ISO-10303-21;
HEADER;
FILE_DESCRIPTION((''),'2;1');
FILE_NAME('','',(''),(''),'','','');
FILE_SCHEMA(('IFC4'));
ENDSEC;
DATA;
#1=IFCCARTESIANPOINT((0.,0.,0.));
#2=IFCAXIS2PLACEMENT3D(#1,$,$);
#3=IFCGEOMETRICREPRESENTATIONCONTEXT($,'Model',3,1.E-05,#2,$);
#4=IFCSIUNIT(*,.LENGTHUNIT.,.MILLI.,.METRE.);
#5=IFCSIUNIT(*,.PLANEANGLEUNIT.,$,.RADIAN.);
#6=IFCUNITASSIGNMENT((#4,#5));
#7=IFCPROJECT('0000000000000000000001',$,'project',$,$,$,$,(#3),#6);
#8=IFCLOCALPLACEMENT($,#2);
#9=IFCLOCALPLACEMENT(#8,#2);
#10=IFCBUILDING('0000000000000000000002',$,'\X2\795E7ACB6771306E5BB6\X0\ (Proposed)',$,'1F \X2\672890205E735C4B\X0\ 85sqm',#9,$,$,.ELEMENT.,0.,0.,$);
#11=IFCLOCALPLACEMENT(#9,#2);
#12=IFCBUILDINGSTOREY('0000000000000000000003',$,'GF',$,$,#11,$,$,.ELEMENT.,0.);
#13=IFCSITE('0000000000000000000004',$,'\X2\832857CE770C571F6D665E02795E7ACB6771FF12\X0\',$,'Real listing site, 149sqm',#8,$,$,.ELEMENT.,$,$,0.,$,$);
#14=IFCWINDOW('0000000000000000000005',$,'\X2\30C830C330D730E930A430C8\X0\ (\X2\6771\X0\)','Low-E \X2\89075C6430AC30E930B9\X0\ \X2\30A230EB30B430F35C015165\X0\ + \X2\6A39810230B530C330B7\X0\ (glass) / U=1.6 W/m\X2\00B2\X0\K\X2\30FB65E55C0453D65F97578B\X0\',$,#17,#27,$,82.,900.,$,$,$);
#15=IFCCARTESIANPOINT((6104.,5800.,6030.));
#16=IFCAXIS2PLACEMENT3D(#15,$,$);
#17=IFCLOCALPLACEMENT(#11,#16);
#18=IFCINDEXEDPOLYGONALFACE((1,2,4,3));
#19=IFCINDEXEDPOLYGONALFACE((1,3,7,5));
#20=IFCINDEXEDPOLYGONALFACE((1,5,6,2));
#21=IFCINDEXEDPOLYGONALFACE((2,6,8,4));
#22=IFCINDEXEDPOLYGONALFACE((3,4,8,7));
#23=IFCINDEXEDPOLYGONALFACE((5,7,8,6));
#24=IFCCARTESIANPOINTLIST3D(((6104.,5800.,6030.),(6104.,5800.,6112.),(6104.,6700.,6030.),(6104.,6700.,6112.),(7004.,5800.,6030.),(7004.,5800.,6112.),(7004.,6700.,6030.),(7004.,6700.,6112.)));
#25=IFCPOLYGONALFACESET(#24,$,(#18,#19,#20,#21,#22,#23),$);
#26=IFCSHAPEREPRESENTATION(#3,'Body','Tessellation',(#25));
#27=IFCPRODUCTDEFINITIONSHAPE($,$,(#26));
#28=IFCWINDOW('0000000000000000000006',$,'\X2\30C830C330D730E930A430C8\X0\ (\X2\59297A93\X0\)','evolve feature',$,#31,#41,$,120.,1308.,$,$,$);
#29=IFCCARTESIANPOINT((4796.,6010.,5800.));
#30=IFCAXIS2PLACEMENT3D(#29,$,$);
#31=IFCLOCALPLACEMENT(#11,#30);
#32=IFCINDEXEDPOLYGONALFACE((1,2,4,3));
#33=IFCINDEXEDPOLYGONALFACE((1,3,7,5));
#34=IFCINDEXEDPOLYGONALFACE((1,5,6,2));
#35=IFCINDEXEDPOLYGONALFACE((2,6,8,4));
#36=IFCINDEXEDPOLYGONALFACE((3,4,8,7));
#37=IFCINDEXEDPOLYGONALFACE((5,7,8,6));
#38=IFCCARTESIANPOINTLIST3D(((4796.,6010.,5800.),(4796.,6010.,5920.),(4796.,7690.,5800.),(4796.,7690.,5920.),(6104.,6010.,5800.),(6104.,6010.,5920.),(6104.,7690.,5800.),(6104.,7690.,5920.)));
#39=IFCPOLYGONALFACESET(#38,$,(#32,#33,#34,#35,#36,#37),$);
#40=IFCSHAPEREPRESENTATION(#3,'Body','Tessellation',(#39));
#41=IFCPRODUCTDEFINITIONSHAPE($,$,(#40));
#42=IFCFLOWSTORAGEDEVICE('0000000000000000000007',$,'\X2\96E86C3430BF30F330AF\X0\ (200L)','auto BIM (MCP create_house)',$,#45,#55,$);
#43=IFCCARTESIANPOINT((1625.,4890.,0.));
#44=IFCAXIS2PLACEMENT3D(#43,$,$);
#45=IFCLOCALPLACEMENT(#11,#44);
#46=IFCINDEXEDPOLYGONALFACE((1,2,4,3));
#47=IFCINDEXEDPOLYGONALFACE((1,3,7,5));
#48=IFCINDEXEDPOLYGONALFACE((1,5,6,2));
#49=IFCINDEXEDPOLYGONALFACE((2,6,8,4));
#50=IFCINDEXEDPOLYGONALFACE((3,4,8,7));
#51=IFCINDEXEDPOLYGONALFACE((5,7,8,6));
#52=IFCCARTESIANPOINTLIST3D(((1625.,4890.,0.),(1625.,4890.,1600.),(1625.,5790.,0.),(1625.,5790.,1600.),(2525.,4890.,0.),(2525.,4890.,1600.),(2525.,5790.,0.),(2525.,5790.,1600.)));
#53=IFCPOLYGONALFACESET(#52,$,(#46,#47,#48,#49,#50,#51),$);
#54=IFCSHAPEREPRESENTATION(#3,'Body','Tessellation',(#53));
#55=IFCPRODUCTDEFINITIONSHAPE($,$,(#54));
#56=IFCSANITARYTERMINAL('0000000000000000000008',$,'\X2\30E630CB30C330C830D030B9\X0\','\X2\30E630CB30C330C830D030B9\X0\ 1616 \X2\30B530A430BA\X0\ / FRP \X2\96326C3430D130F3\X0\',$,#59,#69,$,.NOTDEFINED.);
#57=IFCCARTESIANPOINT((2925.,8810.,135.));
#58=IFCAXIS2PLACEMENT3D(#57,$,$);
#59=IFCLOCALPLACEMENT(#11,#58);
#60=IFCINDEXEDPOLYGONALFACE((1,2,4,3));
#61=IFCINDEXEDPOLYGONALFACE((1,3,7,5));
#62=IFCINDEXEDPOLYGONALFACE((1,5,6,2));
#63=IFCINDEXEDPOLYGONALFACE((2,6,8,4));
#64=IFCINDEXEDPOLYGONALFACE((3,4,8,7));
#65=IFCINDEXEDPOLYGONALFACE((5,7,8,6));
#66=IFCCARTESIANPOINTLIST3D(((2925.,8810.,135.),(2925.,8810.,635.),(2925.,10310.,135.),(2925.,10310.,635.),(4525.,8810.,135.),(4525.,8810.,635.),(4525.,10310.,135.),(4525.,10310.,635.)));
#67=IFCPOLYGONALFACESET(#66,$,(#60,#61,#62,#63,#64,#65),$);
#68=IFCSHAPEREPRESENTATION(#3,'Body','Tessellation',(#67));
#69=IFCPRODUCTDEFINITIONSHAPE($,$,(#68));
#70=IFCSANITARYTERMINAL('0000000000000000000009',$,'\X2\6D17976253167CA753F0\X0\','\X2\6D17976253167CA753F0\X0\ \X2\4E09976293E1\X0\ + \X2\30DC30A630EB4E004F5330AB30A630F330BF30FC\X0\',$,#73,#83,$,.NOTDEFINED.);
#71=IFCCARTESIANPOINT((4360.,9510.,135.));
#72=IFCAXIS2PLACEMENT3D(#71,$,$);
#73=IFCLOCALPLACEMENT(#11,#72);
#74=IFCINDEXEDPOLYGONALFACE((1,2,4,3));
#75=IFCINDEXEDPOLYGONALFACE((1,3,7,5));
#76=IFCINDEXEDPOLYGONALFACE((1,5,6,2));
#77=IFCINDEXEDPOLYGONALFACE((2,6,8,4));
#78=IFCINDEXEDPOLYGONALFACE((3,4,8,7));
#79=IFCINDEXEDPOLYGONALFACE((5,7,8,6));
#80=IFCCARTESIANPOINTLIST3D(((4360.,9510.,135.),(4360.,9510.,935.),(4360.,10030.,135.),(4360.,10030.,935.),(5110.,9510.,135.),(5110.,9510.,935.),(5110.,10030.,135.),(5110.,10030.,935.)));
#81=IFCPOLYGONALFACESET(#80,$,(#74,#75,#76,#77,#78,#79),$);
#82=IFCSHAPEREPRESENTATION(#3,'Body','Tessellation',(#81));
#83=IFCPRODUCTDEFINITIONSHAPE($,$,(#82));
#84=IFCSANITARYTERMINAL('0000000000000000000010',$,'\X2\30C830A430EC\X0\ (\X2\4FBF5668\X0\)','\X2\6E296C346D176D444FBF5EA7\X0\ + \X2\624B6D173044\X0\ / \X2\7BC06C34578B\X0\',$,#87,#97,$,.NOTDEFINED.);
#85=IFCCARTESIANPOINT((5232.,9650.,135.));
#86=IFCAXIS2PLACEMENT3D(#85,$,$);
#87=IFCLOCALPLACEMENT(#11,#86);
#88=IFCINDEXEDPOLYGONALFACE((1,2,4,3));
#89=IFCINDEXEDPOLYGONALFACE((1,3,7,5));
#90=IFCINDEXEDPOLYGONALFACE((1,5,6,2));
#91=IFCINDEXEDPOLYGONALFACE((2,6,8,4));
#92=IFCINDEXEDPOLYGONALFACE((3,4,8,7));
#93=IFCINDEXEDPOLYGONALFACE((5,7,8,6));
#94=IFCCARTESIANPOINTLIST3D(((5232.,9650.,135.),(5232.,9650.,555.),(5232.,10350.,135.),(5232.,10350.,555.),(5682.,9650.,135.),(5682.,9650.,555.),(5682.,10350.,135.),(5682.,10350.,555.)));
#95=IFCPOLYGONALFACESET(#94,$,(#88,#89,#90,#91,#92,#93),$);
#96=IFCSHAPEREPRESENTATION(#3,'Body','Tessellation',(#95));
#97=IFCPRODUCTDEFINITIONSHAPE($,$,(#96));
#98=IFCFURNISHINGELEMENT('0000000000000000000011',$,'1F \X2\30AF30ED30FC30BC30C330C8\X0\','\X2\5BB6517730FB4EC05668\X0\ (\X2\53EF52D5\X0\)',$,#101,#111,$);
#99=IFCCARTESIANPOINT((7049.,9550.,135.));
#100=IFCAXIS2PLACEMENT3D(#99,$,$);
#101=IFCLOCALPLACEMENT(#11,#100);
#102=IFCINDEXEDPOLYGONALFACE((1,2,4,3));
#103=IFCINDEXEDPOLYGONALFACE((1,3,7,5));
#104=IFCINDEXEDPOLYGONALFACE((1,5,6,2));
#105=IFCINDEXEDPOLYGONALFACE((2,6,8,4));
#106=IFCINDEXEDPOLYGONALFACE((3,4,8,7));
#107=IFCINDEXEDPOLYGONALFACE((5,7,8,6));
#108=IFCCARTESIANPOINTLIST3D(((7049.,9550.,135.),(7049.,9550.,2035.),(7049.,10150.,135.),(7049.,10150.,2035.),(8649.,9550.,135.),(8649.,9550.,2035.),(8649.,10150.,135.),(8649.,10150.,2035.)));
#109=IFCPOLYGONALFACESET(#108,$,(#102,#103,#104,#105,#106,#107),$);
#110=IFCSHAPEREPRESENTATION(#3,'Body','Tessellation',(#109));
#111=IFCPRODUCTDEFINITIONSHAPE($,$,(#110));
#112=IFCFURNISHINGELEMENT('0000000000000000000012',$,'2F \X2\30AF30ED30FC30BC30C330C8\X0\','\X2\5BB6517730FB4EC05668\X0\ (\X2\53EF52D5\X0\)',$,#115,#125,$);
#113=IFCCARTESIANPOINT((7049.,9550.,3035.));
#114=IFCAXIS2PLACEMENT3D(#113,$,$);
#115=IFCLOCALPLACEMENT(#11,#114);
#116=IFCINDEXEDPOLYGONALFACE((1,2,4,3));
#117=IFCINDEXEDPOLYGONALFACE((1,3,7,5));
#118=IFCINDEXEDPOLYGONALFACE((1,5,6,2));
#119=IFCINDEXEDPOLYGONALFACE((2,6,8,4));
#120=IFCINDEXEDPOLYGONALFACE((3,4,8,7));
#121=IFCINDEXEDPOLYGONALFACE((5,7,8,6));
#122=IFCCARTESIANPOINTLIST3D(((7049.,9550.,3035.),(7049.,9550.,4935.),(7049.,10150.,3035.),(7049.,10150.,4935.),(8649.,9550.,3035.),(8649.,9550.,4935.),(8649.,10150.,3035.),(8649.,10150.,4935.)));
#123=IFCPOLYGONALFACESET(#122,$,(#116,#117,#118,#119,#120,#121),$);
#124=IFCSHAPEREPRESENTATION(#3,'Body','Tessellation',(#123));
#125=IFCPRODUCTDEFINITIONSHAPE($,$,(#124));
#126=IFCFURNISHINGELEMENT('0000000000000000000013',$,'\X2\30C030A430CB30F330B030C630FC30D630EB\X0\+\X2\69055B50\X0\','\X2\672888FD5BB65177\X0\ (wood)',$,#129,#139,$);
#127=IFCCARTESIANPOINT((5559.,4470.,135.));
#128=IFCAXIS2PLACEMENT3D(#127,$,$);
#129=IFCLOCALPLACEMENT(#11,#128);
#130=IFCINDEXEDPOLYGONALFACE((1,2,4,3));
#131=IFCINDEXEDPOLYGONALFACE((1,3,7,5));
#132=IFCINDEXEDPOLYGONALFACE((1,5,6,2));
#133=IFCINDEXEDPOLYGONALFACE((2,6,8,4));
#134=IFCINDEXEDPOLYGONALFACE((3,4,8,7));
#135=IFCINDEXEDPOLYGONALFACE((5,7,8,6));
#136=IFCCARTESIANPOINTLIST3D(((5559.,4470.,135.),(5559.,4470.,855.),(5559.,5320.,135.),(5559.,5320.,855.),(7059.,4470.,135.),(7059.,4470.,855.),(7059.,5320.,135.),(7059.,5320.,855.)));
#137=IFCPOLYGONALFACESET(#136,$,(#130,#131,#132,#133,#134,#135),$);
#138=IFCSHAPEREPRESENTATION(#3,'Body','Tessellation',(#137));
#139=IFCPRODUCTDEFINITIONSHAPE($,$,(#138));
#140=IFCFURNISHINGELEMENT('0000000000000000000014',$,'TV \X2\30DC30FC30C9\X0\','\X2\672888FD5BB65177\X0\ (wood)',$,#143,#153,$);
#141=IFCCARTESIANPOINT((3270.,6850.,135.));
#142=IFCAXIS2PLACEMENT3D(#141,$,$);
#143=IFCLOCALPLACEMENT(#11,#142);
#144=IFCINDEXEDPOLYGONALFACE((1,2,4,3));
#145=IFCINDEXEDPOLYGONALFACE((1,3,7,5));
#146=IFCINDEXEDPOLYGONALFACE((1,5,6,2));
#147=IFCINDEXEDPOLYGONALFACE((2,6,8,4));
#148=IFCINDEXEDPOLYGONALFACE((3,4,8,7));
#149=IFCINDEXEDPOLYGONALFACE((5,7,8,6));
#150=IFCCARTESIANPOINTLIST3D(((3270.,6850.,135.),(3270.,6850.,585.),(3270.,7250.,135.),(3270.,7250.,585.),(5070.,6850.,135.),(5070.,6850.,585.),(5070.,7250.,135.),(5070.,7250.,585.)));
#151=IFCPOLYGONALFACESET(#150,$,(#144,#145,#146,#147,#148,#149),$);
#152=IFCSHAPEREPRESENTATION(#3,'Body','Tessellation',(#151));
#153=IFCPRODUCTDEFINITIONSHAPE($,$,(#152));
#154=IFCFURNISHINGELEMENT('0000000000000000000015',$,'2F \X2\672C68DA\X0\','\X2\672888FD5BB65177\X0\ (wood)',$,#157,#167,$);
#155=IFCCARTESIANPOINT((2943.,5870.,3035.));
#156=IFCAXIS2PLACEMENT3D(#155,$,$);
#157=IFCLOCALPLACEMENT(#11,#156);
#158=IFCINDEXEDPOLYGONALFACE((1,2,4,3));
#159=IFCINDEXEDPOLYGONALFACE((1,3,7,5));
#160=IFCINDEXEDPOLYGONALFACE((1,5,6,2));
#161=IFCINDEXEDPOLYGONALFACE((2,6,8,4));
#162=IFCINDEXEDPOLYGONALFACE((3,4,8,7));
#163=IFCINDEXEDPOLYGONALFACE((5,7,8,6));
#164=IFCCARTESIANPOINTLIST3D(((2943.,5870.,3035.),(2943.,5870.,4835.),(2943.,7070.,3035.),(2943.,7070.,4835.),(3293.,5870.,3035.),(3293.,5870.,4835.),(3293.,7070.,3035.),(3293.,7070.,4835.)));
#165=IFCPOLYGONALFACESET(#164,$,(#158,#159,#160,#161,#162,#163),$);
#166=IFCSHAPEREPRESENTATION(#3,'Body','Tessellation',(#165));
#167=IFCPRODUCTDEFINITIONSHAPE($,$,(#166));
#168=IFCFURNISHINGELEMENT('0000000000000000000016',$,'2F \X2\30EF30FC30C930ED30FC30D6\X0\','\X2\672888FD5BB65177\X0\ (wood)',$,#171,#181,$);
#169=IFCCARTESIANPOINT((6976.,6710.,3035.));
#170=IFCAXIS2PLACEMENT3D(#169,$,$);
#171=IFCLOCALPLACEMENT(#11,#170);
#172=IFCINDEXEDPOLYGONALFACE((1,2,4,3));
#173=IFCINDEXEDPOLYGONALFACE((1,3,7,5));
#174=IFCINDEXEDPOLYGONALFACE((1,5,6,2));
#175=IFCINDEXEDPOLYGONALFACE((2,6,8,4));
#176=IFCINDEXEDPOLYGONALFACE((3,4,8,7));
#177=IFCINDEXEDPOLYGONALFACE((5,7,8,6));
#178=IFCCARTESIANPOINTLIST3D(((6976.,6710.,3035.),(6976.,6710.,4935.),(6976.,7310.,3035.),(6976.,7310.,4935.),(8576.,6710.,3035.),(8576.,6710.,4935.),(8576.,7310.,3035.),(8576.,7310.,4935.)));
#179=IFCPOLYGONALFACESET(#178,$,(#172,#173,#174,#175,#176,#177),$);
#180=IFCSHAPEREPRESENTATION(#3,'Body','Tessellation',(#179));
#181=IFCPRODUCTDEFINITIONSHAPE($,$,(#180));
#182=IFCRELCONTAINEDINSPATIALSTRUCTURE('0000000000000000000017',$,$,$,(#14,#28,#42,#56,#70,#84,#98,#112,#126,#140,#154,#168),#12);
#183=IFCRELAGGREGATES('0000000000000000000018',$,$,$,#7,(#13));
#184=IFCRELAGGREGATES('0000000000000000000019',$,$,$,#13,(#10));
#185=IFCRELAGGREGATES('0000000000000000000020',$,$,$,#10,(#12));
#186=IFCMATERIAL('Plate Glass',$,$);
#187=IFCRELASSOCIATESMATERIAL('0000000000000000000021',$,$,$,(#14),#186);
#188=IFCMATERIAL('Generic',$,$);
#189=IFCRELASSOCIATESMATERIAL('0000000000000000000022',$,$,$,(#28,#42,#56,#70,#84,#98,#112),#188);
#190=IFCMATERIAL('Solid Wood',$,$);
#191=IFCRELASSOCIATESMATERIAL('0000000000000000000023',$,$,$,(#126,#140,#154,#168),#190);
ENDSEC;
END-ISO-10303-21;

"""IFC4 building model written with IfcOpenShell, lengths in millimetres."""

from ifc_helpers import new_model, si_unit, frame, frame_2d, origin, place, context, project, spatial, rectangle, extrude, material, element, save


model = new_model("IFC4")

# Units and contexts
model_context = context("Model", 3, precision=1e-05, world=origin())
ifc_project = project(units=[si_unit("LENGTHUNIT", "METRE", prefix="MILLI"), si_unit("PLANEANGLEUNIT", "RADIAN")], contexts=[model_context])

# Site, building, storey
site_placement = place(None, origin())
site = spatial("IfcSite", under=ifc_project, at=site_placement, Name="茨城県土浦市神立東２", ObjectType="Real listing site, 149sqm", CompositionType="ELEMENT", RefElevation=0.0)
building_placement = place(site_placement, origin())
building = spatial("IfcBuilding", under=site, at=building_placement, Name="神立東の家 (Proposed)", ObjectType="1F 木造平屋 85sqm", CompositionType="ELEMENT", ElevationOfRefHeight=0.0, ElevationOfTerrain=0.0)
storey_placement = place(building_placement, origin())
storey = spatial("IfcBuildingStorey", under=building, at=storey_placement, Name="GF", CompositionType="ELEMENT", Elevation=0.0)

# Shared definitions
ifc_material_1 = material(Name="Solid Wood")
ifc_material_2 = material(Name="Plate Glass")

# Windows
window_1_placement = place(storey_placement, frame((6104.0, 5800.0, 6030.0)))
element("IfcWindow", 1, at=window_1_placement, inside=storey, material=ifc_material_2, Name="トップライト (東)", Description="Low-E 複層ガラス アルゴン封入 + 樹脂サッシ (glass) / U=1.6 W/m²K・日射取得型", OverallHeight=82.0, OverallWidth=900.0, context=model_context, shape_type="SweptSolid", body=[
    extrude(rectangle(XDim=900.0, YDim=900.0, at=frame_2d((450.0, 450.0))), frame((6104.0, 5800.0, 6030.0)), (0.0, 0.0, 1.0), 82.0),
])
ifc_material_3 = material(Name="Generic")
window_2_placement = place(storey_placement, frame((4796.0, 6010.0, 5800.0)))
element("IfcWindow", 2, at=window_2_placement, inside=storey, material=ifc_material_3, Name="トップライト (天窓)", Description="evolve feature", OverallHeight=120.0, OverallWidth=1308.0, context=model_context, shape_type="SweptSolid", body=[
    extrude(rectangle(XDim=1308.0, YDim=1680.0, at=frame_2d((654.0, 840.0))), frame((4796.0, 6010.0, 5800.0)), (0.0, 0.0, 1.0), 120.0),
])

# Flow storage device
flow_storage_device_placement = place(storey_placement, frame((1625.0, 4890.0, 0.0)))
element("IfcFlowStorageDevice", 3, at=flow_storage_device_placement, inside=storey, material=ifc_material_3, Name="雨水タンク (200L)", Description="auto BIM (MCP create_house)", context=model_context, shape_type="SweptSolid", body=[
    extrude(rectangle(XDim=900.0, YDim=900.0, at=frame_2d((450.0, 450.0))), frame((1625.0, 4890.0, 0.0)), (0.0, 0.0, 1.0), 1600.0),
])

# Sanitary terminals
sanitary_terminal_1_placement = place(storey_placement, frame((2925.0, 8810.0, 135.0)))
element("IfcSanitaryTerminal", 4, at=sanitary_terminal_1_placement, inside=storey, material=ifc_material_3, Name="ユニットバス", Description="ユニットバス 1616 サイズ / FRP 防水パン", PredefinedType="NOTDEFINED", context=model_context, shape_type="SweptSolid", body=[
    extrude(rectangle(XDim=1600.0, YDim=1500.0, at=frame_2d((800.0, 750.0))), frame((2925.0, 8810.0, 135.0)), (0.0, 0.0, 1.0), 500.0),
])
sanitary_terminal_2_placement = place(storey_placement, frame((4360.0, 9510.0, 135.0)))
element("IfcSanitaryTerminal", 5, at=sanitary_terminal_2_placement, inside=storey, material=ifc_material_3, Name="洗面化粧台", Description="洗面化粧台 三面鏡 + ボウル一体カウンター", PredefinedType="NOTDEFINED", context=model_context, shape_type="SweptSolid", body=[
    extrude(rectangle(XDim=750.0, YDim=520.0, at=frame_2d((375.0, 260.0))), frame((4360.0, 9510.0, 135.0)), (0.0, 0.0, 1.0), 800.0),
])
sanitary_terminal_3_placement = place(storey_placement, frame((5232.0, 9650.0, 135.0)))
element("IfcSanitaryTerminal", 6, at=sanitary_terminal_3_placement, inside=storey, material=ifc_material_3, Name="トイレ (便器)", Description="温水洗浄便座 + 手洗い / 節水型", PredefinedType="NOTDEFINED", context=model_context, shape_type="SweptSolid", body=[
    extrude(rectangle(XDim=450.0, YDim=700.0, at=frame_2d((225.0, 350.0))), frame((5232.0, 9650.0, 135.0)), (0.0, 0.0, 1.0), 420.0),
])

# Furnishing elements
furnishing_1_placement = place(storey_placement, frame((7049.0, 9550.0, 135.0)))
element("IfcFurnishingElement", 7, at=furnishing_1_placement, inside=storey, material=ifc_material_3, Name="1F クローゼット", Description="家具・什器 (可動)", context=model_context, shape_type="SweptSolid", body=[
    extrude(rectangle(XDim=1600.0, YDim=600.0, at=frame_2d((800.0, 300.0))), frame((7049.0, 9550.0, 135.0)), (0.0, 0.0, 1.0), 1900.0),
])
furnishing_2_placement = place(storey_placement, frame((7049.0, 9550.0, 3035.0)))
element("IfcFurnishingElement", 8, at=furnishing_2_placement, inside=storey, material=ifc_material_3, Name="2F クローゼット", Description="家具・什器 (可動)", context=model_context, shape_type="SweptSolid", body=[
    extrude(rectangle(XDim=1600.0, YDim=600.0, at=frame_2d((800.0, 300.0))), frame((7049.0, 9550.0, 3035.0)), (0.0, 0.0, 1.0), 1900.0),
])
furnishing_3_placement = place(storey_placement, frame((5559.0, 4470.0, 135.0)))
element("IfcFurnishingElement", 9, at=furnishing_3_placement, inside=storey, material=ifc_material_1, Name="ダイニングテーブル+椅子", Description="木製家具 (wood)", context=model_context, shape_type="SweptSolid", body=[
    extrude(rectangle(XDim=1500.0, YDim=850.0, at=frame_2d((750.0, 425.0))), frame((5559.0, 4470.0, 135.0)), (0.0, 0.0, 1.0), 720.0),
])
furnishing_4_placement = place(storey_placement, frame((3270.0, 6850.0, 135.0)))
element("IfcFurnishingElement", 10, at=furnishing_4_placement, inside=storey, material=ifc_material_1, Name="TV ボード", Description="木製家具 (wood)", context=model_context, shape_type="SweptSolid", body=[
    extrude(rectangle(XDim=1800.0, YDim=400.0, at=frame_2d((900.0, 200.0))), frame((3270.0, 6850.0, 135.0)), (0.0, 0.0, 1.0), 450.0),
])
furnishing_5_placement = place(storey_placement, frame((2943.0, 5870.0, 3035.0)))
element("IfcFurnishingElement", 11, at=furnishing_5_placement, inside=storey, material=ifc_material_1, Name="2F 本棚", Description="木製家具 (wood)", context=model_context, shape_type="SweptSolid", body=[
    extrude(rectangle(XDim=350.0, YDim=1200.0, at=frame_2d((175.0, 600.0))), frame((2943.0, 5870.0, 3035.0)), (0.0, 0.0, 1.0), 1800.0),
])
furnishing_6_placement = place(storey_placement, frame((6976.0, 6710.0, 3035.0)))
element("IfcFurnishingElement", 12, at=furnishing_6_placement, inside=storey, material=ifc_material_1, Name="2F ワードローブ", Description="木製家具 (wood)", context=model_context, shape_type="SweptSolid", body=[
    extrude(rectangle(XDim=1600.0, YDim=600.0, at=frame_2d((800.0, 300.0))), frame((6976.0, 6710.0, 3035.0)), (0.0, 0.0, 1.0), 1900.0),
])

save(model, "model.ifc")
